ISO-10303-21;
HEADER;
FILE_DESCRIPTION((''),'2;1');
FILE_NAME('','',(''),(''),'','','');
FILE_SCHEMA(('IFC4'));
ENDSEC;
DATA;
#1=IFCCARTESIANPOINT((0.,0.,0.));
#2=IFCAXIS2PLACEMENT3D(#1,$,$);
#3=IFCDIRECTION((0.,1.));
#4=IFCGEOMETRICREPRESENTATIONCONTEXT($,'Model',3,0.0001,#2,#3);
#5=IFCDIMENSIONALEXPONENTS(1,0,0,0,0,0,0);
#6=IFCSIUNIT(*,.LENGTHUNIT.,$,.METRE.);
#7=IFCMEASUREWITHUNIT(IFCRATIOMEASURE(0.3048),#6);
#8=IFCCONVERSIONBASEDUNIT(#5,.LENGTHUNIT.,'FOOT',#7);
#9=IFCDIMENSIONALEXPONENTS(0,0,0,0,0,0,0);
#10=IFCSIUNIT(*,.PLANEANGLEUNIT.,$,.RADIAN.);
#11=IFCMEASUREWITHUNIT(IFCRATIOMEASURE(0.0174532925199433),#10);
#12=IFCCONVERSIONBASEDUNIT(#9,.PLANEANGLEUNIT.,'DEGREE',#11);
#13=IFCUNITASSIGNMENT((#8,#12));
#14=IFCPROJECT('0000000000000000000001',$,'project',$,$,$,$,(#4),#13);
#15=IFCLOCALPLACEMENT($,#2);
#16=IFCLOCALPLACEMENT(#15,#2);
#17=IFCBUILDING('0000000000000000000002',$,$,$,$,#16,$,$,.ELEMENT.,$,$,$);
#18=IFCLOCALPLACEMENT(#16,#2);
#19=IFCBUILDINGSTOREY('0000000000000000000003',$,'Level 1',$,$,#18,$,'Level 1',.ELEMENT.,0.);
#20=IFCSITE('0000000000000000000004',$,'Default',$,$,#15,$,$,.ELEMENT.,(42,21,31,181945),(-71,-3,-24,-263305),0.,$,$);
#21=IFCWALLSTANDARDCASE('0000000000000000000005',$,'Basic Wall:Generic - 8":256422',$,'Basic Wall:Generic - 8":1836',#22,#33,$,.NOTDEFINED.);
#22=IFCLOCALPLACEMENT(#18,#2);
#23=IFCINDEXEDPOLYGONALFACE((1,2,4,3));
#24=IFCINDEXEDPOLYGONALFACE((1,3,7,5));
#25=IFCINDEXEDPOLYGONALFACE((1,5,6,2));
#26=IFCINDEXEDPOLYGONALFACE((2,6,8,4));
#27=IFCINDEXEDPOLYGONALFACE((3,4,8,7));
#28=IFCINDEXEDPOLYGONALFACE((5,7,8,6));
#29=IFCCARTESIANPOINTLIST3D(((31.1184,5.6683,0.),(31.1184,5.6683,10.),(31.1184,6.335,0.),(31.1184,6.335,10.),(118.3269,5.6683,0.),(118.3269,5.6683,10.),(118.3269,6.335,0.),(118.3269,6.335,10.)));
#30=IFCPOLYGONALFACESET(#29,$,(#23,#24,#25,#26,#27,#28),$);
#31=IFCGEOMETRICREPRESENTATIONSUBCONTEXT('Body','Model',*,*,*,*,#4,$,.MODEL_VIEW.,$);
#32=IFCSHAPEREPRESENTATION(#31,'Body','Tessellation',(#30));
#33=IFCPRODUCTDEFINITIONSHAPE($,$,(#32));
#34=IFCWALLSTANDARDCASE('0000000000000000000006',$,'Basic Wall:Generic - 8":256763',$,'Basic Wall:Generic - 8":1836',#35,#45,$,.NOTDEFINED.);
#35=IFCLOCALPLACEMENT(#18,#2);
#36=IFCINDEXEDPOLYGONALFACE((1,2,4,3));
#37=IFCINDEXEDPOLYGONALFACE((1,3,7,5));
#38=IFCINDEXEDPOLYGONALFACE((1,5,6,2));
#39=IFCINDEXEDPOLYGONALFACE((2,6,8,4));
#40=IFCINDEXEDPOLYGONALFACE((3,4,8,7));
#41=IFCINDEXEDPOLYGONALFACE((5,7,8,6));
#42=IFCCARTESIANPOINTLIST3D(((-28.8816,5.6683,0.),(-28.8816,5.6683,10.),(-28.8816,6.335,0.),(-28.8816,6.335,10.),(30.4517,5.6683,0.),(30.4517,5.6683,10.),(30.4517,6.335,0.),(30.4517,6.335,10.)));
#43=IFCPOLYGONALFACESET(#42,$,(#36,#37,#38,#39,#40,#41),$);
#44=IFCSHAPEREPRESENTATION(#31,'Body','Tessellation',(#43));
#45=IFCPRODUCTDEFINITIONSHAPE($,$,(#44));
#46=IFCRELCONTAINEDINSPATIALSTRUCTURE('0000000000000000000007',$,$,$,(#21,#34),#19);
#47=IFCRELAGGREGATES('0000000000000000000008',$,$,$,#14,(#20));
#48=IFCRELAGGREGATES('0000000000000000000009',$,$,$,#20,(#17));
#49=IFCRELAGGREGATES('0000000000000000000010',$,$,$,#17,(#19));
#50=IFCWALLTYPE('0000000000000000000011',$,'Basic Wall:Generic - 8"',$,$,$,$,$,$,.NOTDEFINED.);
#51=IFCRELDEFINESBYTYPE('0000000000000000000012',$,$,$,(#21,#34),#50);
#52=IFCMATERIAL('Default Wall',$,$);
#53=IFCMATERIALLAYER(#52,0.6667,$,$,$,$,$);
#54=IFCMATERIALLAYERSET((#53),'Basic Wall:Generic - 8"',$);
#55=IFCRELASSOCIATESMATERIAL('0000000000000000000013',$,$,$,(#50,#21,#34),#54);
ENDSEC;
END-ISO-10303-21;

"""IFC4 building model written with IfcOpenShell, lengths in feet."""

from ifc_helpers import new_model, entity, si_unit, converted_unit, direction, frame, frame_2d, origin, place, context, subcontext, project, spatial, rectangle, extrude, material, layer, layer_set, layer_usage, type_object, element, save


model = new_model("IFC4")

# Units and contexts
model_context = context("Model", 3, precision=0.0001, world=origin(), true_north=direction((0.0, 1.0)))
body_context = subcontext(model_context, "Body", "Model", "MODEL_VIEW")
ifc_project = project(units=[converted_unit("LENGTHUNIT", "FOOT", entity("IfcRatioMeasure", 0.3048), si_unit("LENGTHUNIT", "METRE"), dimensions=[1, 0, 0, 0, 0, 0, 0]), converted_unit("PLANEANGLEUNIT", "DEGREE", entity("IfcRatioMeasure", 0.0174532925199433), si_unit("PLANEANGLEUNIT", "RADIAN"), dimensions=[0, 0, 0, 0, 0, 0, 0])], contexts=[model_context])

# Site, building, storey
site_placement = place(None, origin())
site = spatial("IfcSite", under=ifc_project, at=site_placement, Name="Default", CompositionType="ELEMENT", RefLatitude=(42, 21, 31, 181945), RefLongitude=(-71, -3, -24, -263305), RefElevation=0.0)
building_placement = place(site_placement, origin())
building = spatial("IfcBuilding", under=site, at=building_placement, CompositionType="ELEMENT")
storey_placement = place(building_placement, origin())
storey = spatial("IfcBuildingStorey", under=building, at=storey_placement, Name="Level 1", LongName="Level 1", CompositionType="ELEMENT", Elevation=0.0)

# Walls
ifc_material_1 = material(Name="Default Wall")
ifc_layer = layer(ifc_material_1, 0.6667)
ifc_layer_set = layer_set([ifc_layer], Name="Basic Wall:Generic - 8\"")
ifc_layer_usage_1 = layer_usage(ifc_layer_set, "AXIS2", "NEGATIVE", 0.3333)
wall_type = type_object("IfcWallType", Name="Basic Wall:Generic - 8\"", PredefinedType="NOTDEFINED", material=ifc_layer_set)
wall_1_placement = place(storey_placement, frame((31.1184, 6.0017, 0.0)))
element("IfcWallStandardCase", 1, at=wall_1_placement, inside=storey, type_object=wall_type, material=ifc_layer_usage_1, Name="Basic Wall:Generic - 8\":256422", ObjectType="Basic Wall:Generic - 8\":1836", PredefinedType="NOTDEFINED", context=body_context, shape_type="SweptSolid", body=[
    extrude(rectangle(XDim=87.2085, YDim=0.6667, at=frame_2d((43.6043, 0.0), x_axis=(-1.0, 0.0))), origin(), (0.0, 0.0, 1.0), 10.0),
])
ifc_layer_usage_2 = layer_usage(ifc_layer_set, "AXIS2", "NEGATIVE", 0.3333)
wall_2_placement = place(storey_placement, frame((30.4517, 6.0017, 0.0), z_axis=(0.0, 0.0, 1.0), x_axis=(-1.0, 0.0, 0.0)))
element("IfcWallStandardCase", 2, at=wall_2_placement, inside=storey, type_object=wall_type, material=ifc_layer_usage_2, Name="Basic Wall:Generic - 8\":256763", ObjectType="Basic Wall:Generic - 8\":1836", PredefinedType="NOTDEFINED", context=body_context, shape_type="SweptSolid", body=[
    extrude(rectangle(XDim=59.3333, YDim=0.6667, at=frame_2d((29.6667, 0.0), x_axis=(-1.0, 0.0))), origin(), (0.0, 0.0, 1.0), 10.0),
])

save(model, "model.ifc")
